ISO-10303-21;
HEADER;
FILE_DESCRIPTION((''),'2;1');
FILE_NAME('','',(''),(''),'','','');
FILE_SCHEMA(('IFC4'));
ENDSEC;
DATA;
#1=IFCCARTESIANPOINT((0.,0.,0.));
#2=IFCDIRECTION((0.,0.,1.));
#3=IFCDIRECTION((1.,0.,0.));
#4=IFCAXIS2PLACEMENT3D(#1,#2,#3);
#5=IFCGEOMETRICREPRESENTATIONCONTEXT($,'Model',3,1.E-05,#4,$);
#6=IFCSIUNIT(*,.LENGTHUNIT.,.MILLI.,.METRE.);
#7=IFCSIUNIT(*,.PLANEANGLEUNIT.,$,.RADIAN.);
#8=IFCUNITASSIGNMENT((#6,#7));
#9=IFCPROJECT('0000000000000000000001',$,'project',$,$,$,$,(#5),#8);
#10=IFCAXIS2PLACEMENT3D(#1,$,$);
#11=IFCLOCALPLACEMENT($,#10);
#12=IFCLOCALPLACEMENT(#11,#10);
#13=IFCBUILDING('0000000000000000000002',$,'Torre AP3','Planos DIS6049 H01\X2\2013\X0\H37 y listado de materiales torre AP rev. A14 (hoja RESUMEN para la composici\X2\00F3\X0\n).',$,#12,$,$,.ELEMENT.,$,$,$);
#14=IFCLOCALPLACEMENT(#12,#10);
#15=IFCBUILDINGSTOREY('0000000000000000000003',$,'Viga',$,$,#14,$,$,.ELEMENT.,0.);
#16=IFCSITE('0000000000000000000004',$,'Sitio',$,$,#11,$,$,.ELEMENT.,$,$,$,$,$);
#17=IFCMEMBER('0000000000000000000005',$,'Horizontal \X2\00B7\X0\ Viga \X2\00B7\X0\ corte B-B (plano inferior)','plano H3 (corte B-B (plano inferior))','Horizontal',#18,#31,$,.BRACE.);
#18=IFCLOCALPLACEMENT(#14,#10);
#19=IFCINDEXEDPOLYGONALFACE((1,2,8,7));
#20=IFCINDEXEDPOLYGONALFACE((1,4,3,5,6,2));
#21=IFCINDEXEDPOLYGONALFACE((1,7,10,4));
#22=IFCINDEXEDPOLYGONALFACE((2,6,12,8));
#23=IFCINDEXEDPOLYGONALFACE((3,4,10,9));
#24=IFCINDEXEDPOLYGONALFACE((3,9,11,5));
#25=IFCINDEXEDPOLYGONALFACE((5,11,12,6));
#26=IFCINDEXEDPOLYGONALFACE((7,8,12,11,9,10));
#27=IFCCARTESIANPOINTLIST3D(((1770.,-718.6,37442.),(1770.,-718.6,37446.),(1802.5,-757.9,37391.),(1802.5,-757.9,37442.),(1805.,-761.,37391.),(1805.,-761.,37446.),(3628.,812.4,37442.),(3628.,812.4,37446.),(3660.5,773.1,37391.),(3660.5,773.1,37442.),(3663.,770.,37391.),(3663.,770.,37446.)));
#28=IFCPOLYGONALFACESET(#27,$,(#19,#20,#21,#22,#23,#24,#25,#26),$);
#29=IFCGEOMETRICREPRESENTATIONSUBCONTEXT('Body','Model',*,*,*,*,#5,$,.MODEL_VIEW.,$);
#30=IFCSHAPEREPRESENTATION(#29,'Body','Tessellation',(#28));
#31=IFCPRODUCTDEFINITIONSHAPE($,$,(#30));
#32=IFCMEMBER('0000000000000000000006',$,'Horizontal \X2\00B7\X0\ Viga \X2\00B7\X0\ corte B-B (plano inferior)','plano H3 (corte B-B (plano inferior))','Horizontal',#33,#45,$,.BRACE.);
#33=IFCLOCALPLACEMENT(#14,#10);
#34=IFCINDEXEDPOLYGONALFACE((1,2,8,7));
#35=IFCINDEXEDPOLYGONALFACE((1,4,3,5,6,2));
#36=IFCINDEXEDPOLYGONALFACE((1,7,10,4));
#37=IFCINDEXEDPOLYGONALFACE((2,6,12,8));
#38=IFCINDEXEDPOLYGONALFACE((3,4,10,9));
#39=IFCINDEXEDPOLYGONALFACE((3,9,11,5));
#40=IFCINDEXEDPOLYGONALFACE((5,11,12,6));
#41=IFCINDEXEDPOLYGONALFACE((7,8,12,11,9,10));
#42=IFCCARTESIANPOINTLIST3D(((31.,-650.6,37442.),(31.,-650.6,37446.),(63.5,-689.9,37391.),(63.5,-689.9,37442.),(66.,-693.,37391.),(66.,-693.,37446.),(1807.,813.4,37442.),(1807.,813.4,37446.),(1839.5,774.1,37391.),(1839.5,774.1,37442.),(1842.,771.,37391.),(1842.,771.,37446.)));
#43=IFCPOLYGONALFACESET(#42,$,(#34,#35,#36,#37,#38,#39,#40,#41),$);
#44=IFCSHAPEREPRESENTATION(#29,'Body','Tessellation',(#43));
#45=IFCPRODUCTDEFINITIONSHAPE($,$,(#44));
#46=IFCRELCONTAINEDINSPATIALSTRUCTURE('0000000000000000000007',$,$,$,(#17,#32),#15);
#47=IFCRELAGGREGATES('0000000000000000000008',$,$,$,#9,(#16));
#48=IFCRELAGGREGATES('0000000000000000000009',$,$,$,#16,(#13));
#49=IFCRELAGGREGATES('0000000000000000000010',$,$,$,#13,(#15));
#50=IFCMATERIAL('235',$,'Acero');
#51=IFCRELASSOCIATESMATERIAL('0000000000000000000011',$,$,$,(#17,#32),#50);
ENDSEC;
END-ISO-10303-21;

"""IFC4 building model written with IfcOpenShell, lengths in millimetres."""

from ifc_helpers import new_model, si_unit, frame, frame_2d, origin, origin_with_axes, place, context, subcontext, project, spatial, l_section, extrude, material, element, save


model = new_model("IFC4")

# Units and contexts
model_context = context("Model", 3, precision=1e-05, world=origin_with_axes())
body_context = subcontext(model_context, "Body", "Model", "MODEL_VIEW")
ifc_project = project(units=[si_unit("LENGTHUNIT", "METRE", prefix="MILLI"), si_unit("PLANEANGLEUNIT", "RADIAN")], contexts=[model_context])

# Site, building, storey
site_placement = place(None, origin())
site = spatial("IfcSite", under=ifc_project, at=site_placement, Name="Sitio", CompositionType="ELEMENT")
building_placement = place(site_placement, origin())
building = spatial("IfcBuilding", under=site, at=building_placement, Name="Torre AP3", Description="Planos DIS6049 H01–H37 y listado de materiales torre AP rev. A14 (hoja RESUMEN para la composición).", CompositionType="ELEMENT")
storey_placement = place(building_placement, origin())
storey = spatial("IfcBuildingStorey", under=building, at=storey_placement, Name="Viga", CompositionType="ELEMENT", Elevation=0.0)

# Members
ifc_material = material(Name="235", Category="Acero")
member_1_placement = place(storey_placement, frame((3663.0, 770.0, 37446.0), z_axis=(-0.77175, -0.635926, 0.0), x_axis=(-0.635926, 0.77175, 0.0)))
element("IfcMember", 1, at=member_1_placement, inside=storey, material=ifc_material, Name="Horizontal · Viga · corte B-B (plano inferior)", Description="plano H3 (corte B-B (plano inferior))", ObjectType="Horizontal", PredefinedType="BRACE", context=body_context, shape_type="SweptSolid", body=[
    extrude(l_section(Depth=55.0, Width=55.0, Thickness=4.0, at=frame_2d((27.5, 27.5))), None, (0.0, 0.0, 1.0), 2407.5),
])
member_2_placement = place(storey_placement, frame((1842.0, 771.0, 37446.0), z_axis=(-0.771629, -0.636073, 0.0), x_axis=(-0.636073, 0.771629, 0.0)))
element("IfcMember", 2, at=member_2_placement, inside=storey, material=ifc_material, Name="Horizontal · Viga · corte B-B (plano inferior)", Description="plano H3 (corte B-B (plano inferior))", ObjectType="Horizontal", PredefinedType="BRACE", context=body_context, shape_type="SweptSolid", body=[
    extrude(l_section(Depth=55.0, Width=55.0, Thickness=4.0, at=frame_2d((27.5, 27.5))), None, (0.0, 0.0, 1.0), 2301.6),
])

save(model, "model.ifc")
